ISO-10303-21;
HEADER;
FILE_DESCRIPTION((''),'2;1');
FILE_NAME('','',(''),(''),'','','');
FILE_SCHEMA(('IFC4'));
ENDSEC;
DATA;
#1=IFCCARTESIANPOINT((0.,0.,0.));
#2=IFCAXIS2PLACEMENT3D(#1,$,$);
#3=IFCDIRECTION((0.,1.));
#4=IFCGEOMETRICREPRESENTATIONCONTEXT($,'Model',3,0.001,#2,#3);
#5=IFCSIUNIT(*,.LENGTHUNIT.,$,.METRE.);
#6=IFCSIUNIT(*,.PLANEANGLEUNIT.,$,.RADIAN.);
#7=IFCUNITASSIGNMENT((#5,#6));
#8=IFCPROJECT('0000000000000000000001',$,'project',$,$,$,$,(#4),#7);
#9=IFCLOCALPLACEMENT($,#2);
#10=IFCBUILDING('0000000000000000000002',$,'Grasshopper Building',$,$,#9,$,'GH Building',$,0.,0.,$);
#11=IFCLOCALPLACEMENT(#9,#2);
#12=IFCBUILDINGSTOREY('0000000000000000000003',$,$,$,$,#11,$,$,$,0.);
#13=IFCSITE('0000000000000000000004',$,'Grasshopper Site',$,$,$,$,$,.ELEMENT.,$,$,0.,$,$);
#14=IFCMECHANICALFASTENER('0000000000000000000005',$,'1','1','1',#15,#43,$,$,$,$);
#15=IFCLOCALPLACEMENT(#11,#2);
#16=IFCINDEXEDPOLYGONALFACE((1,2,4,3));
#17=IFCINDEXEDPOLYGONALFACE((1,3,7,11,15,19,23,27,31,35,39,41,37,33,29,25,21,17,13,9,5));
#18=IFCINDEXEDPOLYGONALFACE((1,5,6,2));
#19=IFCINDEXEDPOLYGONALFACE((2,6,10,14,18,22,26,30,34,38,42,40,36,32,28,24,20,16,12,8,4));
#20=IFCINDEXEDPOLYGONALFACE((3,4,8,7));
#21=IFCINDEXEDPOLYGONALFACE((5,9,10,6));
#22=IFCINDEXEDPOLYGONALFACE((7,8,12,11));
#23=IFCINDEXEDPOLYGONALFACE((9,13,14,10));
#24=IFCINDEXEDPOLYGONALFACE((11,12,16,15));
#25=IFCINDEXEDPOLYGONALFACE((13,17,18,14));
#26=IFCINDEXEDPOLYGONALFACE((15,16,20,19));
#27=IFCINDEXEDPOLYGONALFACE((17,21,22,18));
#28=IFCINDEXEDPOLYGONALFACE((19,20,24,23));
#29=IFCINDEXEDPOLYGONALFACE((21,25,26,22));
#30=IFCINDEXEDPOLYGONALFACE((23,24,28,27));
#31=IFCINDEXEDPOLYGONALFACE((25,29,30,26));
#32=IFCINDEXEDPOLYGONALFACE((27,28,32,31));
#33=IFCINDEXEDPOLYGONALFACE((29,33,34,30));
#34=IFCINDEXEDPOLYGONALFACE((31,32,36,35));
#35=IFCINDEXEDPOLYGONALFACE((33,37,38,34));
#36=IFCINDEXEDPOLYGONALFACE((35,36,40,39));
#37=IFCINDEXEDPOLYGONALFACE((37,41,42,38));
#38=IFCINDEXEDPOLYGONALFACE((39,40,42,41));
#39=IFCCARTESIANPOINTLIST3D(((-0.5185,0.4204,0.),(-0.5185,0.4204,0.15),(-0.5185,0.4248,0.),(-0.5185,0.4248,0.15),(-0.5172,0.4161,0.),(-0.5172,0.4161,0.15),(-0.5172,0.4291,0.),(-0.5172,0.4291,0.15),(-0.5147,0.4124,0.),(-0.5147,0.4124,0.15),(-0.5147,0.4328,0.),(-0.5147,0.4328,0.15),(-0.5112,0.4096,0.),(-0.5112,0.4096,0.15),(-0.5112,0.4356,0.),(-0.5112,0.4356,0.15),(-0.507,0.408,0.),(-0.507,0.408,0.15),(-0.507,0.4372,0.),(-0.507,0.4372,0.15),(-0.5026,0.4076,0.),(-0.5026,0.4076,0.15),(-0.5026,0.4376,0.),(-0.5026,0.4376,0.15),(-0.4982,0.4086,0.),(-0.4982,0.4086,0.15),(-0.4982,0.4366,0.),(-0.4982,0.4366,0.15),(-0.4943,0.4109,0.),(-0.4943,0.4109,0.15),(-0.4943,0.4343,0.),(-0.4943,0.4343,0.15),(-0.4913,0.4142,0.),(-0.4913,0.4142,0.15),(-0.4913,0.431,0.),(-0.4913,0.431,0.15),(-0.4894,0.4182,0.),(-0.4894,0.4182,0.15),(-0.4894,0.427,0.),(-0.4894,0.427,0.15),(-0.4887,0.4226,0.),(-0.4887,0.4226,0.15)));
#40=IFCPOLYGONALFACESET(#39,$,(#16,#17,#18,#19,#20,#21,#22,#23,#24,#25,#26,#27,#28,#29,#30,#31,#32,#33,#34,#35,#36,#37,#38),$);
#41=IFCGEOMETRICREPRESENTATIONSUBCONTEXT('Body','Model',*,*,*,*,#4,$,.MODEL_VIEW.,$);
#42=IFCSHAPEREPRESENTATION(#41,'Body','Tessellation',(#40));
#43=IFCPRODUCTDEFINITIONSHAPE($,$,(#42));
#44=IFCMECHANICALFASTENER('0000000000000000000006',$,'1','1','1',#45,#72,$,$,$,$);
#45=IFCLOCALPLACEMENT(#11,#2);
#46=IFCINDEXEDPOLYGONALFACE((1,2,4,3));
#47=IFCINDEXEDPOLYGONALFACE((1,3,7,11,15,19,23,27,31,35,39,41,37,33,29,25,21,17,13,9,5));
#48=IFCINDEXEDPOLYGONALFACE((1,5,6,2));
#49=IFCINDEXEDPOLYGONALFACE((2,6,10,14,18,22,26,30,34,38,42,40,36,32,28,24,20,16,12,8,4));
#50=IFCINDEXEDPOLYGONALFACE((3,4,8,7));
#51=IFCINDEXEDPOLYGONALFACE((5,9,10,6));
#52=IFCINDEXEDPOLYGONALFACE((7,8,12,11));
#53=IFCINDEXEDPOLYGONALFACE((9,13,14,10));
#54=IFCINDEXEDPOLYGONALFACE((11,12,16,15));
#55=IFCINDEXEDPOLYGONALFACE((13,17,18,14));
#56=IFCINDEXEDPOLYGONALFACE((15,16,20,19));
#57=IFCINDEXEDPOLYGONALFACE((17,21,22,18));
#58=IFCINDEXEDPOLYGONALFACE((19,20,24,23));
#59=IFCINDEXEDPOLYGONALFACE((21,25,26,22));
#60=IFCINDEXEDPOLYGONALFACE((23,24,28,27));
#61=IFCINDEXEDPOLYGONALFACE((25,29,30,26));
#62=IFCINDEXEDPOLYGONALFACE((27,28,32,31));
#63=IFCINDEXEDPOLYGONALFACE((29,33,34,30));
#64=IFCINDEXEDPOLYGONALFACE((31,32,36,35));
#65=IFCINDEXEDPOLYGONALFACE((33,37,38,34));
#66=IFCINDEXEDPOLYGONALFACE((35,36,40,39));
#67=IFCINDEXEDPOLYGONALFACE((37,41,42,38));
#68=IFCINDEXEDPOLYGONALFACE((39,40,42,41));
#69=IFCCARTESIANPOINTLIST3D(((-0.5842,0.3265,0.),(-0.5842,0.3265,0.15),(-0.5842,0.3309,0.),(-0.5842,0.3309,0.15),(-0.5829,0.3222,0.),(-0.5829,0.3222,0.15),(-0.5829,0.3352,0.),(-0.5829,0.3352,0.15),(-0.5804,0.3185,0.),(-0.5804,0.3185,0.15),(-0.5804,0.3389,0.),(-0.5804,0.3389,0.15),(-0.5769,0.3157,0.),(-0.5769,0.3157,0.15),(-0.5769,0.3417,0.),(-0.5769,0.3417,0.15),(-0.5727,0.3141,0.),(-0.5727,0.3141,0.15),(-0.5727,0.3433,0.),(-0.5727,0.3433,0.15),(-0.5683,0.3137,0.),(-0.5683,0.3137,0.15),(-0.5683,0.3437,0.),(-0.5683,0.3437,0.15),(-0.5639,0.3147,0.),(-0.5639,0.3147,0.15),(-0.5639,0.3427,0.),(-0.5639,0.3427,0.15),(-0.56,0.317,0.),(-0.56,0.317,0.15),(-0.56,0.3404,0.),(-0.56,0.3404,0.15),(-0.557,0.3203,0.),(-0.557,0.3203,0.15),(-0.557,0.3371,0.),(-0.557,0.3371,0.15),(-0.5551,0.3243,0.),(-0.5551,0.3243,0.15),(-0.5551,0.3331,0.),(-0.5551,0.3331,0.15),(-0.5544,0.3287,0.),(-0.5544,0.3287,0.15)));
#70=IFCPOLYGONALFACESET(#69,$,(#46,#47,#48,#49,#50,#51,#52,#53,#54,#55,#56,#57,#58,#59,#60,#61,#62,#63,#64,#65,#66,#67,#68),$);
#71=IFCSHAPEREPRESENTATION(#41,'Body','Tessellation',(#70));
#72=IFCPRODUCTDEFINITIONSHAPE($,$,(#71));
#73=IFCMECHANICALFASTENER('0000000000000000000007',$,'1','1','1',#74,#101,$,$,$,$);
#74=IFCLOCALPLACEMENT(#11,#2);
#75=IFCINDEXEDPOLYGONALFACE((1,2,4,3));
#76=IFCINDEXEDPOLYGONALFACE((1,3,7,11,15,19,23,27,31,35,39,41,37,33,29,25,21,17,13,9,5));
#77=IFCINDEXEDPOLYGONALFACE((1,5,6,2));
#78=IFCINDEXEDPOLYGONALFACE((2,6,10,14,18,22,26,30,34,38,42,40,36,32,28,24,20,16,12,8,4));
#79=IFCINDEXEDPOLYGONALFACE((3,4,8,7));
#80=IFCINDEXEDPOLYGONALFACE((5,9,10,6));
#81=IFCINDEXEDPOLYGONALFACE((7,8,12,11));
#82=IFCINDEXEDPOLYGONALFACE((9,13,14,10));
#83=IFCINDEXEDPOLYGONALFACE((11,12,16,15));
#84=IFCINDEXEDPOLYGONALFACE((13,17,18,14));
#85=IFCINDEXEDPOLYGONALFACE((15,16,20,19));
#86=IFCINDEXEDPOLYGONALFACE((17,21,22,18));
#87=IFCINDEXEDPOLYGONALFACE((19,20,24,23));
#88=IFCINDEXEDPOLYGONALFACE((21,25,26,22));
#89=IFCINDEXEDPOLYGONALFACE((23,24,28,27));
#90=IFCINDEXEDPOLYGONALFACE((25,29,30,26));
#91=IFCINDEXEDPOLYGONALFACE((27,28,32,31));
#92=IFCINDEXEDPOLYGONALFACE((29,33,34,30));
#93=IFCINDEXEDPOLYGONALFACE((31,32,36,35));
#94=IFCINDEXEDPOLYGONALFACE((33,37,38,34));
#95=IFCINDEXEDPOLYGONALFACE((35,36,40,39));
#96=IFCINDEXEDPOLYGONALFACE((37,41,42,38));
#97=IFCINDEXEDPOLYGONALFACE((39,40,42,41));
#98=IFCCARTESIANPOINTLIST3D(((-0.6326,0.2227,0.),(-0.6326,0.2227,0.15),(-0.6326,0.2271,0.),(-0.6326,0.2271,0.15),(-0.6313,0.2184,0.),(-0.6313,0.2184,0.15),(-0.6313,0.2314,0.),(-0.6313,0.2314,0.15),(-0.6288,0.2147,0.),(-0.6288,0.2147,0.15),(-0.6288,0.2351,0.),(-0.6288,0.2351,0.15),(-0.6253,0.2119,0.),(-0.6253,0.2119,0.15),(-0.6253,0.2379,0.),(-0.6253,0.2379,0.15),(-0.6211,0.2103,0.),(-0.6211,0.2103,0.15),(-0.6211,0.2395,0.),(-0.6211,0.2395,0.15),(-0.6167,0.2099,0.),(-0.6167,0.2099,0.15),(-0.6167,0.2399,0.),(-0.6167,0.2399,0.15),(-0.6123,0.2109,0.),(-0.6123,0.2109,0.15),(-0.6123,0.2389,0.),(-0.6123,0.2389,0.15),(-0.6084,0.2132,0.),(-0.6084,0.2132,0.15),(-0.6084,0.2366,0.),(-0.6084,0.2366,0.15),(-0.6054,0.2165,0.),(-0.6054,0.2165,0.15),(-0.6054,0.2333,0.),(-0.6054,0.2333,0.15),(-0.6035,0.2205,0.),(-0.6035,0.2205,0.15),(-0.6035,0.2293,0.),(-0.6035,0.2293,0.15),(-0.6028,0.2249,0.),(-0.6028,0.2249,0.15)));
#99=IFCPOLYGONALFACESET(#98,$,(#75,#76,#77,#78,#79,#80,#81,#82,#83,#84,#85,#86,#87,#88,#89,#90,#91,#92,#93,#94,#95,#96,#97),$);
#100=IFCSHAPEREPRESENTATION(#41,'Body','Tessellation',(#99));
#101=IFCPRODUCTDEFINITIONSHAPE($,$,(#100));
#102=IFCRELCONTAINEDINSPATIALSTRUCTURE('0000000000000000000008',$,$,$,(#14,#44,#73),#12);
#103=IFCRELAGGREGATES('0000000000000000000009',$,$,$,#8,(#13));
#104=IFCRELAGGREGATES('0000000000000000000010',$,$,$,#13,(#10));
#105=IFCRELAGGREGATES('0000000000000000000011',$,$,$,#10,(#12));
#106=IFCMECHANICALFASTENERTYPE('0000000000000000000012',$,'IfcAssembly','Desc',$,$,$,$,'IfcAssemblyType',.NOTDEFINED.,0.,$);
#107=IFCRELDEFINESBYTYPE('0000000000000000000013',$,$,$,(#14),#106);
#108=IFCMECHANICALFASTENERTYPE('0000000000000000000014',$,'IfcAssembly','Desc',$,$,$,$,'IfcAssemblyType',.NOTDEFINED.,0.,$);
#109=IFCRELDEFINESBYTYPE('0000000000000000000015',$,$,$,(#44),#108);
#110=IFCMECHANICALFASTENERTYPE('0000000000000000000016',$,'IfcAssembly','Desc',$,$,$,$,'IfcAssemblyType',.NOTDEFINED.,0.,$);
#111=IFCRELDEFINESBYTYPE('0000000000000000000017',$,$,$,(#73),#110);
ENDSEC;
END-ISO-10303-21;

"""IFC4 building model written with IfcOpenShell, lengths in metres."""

from ifc_helpers import new_model, si_unit, direction, frame, origin, place, context, subcontext, project, spatial, circle, extrude, source, transform, mapped, type_object, type_shapes, element, save


model = new_model("IFC4")

# Units and contexts
model_context = context("Model", 3, precision=0.001, world=origin(), true_north=direction((0.0, 1.0)))
body_context = subcontext(model_context, "Body", "Model", "MODEL_VIEW")
ifc_project = project(units=[si_unit("LENGTHUNIT", "METRE"), si_unit("PLANEANGLEUNIT", "RADIAN")], contexts=[model_context])

# Site, building, storey
site = spatial("IfcSite", under=ifc_project, Name="Grasshopper Site", CompositionType="ELEMENT", RefElevation=0.0)
building_placement = place(None, origin())
building = spatial("IfcBuilding", under=site, at=building_placement, Name="Grasshopper Building", LongName="GH Building", ElevationOfRefHeight=0.0, ElevationOfTerrain=0.0)
storey_placement = place(building_placement, origin())
storey = spatial("IfcBuildingStorey", under=building, at=storey_placement, Elevation=0.0)

# Mechanical fasteners
mechanical_fastener_type_1 = type_object("IfcMechanicalFastenerType", Name="IfcAssembly", Description="Desc", ElementType="IfcAssemblyType", NominalDiameter=0.0)
shared_shape_1 = source(origin(), body_context, "Body", "SweptSolid", [
    extrude(circle(Radius=0.015), frame((-0.5037, 0.4226, 0.0)), (0.0, 0.0, 1.0), 0.15),
])
type_shapes(mechanical_fastener_type_1, [shared_shape_1])
mechanical_fastener_1_placement = place(storey_placement, origin())
element("IfcMechanicalFastener", 1, at=mechanical_fastener_1_placement, inside=storey, type_object=mechanical_fastener_type_1, Name="1", Description="1", ObjectType="1", context=body_context, shape_type="MappedRepresentation", body=[
    mapped(shared_shape_1, transform((0.0, 0.0, 0.0), scale=1.0)),
])
mechanical_fastener_type_2 = type_object("IfcMechanicalFastenerType", Name="IfcAssembly", Description="Desc", ElementType="IfcAssemblyType", NominalDiameter=0.0)
shared_shape_2 = source(origin(), body_context, "Body", "SweptSolid", [
    extrude(circle(Radius=0.015), frame((-0.5694, 0.3287, 0.0)), (0.0, 0.0, 1.0), 0.15),
])
type_shapes(mechanical_fastener_type_2, [shared_shape_2])
mechanical_fastener_2_placement = place(storey_placement, origin())
element("IfcMechanicalFastener", 2, at=mechanical_fastener_2_placement, inside=storey, type_object=mechanical_fastener_type_2, Name="1", Description="1", ObjectType="1", context=body_context, shape_type="MappedRepresentation", body=[
    mapped(shared_shape_2, transform((0.0, 0.0, 0.0), scale=1.0)),
])
mechanical_fastener_type_3 = type_object("IfcMechanicalFastenerType", Name="IfcAssembly", Description="Desc", ElementType="IfcAssemblyType", NominalDiameter=0.0)
shared_shape_3 = source(origin(), body_context, "Body", "SweptSolid", [
    extrude(circle(Radius=0.015), frame((-0.6178, 0.2249, 0.0)), (0.0, 0.0, 1.0), 0.15),
])
type_shapes(mechanical_fastener_type_3, [shared_shape_3])
mechanical_fastener_3_placement = place(storey_placement, origin())
element("IfcMechanicalFastener", 3, at=mechanical_fastener_3_placement, inside=storey, type_object=mechanical_fastener_type_3, Name="1", Description="1", ObjectType="1", context=body_context, shape_type="MappedRepresentation", body=[
    mapped(shared_shape_3, transform((0.0, 0.0, 0.0), scale=1.0)),
])

save(model, "model.ifc")
